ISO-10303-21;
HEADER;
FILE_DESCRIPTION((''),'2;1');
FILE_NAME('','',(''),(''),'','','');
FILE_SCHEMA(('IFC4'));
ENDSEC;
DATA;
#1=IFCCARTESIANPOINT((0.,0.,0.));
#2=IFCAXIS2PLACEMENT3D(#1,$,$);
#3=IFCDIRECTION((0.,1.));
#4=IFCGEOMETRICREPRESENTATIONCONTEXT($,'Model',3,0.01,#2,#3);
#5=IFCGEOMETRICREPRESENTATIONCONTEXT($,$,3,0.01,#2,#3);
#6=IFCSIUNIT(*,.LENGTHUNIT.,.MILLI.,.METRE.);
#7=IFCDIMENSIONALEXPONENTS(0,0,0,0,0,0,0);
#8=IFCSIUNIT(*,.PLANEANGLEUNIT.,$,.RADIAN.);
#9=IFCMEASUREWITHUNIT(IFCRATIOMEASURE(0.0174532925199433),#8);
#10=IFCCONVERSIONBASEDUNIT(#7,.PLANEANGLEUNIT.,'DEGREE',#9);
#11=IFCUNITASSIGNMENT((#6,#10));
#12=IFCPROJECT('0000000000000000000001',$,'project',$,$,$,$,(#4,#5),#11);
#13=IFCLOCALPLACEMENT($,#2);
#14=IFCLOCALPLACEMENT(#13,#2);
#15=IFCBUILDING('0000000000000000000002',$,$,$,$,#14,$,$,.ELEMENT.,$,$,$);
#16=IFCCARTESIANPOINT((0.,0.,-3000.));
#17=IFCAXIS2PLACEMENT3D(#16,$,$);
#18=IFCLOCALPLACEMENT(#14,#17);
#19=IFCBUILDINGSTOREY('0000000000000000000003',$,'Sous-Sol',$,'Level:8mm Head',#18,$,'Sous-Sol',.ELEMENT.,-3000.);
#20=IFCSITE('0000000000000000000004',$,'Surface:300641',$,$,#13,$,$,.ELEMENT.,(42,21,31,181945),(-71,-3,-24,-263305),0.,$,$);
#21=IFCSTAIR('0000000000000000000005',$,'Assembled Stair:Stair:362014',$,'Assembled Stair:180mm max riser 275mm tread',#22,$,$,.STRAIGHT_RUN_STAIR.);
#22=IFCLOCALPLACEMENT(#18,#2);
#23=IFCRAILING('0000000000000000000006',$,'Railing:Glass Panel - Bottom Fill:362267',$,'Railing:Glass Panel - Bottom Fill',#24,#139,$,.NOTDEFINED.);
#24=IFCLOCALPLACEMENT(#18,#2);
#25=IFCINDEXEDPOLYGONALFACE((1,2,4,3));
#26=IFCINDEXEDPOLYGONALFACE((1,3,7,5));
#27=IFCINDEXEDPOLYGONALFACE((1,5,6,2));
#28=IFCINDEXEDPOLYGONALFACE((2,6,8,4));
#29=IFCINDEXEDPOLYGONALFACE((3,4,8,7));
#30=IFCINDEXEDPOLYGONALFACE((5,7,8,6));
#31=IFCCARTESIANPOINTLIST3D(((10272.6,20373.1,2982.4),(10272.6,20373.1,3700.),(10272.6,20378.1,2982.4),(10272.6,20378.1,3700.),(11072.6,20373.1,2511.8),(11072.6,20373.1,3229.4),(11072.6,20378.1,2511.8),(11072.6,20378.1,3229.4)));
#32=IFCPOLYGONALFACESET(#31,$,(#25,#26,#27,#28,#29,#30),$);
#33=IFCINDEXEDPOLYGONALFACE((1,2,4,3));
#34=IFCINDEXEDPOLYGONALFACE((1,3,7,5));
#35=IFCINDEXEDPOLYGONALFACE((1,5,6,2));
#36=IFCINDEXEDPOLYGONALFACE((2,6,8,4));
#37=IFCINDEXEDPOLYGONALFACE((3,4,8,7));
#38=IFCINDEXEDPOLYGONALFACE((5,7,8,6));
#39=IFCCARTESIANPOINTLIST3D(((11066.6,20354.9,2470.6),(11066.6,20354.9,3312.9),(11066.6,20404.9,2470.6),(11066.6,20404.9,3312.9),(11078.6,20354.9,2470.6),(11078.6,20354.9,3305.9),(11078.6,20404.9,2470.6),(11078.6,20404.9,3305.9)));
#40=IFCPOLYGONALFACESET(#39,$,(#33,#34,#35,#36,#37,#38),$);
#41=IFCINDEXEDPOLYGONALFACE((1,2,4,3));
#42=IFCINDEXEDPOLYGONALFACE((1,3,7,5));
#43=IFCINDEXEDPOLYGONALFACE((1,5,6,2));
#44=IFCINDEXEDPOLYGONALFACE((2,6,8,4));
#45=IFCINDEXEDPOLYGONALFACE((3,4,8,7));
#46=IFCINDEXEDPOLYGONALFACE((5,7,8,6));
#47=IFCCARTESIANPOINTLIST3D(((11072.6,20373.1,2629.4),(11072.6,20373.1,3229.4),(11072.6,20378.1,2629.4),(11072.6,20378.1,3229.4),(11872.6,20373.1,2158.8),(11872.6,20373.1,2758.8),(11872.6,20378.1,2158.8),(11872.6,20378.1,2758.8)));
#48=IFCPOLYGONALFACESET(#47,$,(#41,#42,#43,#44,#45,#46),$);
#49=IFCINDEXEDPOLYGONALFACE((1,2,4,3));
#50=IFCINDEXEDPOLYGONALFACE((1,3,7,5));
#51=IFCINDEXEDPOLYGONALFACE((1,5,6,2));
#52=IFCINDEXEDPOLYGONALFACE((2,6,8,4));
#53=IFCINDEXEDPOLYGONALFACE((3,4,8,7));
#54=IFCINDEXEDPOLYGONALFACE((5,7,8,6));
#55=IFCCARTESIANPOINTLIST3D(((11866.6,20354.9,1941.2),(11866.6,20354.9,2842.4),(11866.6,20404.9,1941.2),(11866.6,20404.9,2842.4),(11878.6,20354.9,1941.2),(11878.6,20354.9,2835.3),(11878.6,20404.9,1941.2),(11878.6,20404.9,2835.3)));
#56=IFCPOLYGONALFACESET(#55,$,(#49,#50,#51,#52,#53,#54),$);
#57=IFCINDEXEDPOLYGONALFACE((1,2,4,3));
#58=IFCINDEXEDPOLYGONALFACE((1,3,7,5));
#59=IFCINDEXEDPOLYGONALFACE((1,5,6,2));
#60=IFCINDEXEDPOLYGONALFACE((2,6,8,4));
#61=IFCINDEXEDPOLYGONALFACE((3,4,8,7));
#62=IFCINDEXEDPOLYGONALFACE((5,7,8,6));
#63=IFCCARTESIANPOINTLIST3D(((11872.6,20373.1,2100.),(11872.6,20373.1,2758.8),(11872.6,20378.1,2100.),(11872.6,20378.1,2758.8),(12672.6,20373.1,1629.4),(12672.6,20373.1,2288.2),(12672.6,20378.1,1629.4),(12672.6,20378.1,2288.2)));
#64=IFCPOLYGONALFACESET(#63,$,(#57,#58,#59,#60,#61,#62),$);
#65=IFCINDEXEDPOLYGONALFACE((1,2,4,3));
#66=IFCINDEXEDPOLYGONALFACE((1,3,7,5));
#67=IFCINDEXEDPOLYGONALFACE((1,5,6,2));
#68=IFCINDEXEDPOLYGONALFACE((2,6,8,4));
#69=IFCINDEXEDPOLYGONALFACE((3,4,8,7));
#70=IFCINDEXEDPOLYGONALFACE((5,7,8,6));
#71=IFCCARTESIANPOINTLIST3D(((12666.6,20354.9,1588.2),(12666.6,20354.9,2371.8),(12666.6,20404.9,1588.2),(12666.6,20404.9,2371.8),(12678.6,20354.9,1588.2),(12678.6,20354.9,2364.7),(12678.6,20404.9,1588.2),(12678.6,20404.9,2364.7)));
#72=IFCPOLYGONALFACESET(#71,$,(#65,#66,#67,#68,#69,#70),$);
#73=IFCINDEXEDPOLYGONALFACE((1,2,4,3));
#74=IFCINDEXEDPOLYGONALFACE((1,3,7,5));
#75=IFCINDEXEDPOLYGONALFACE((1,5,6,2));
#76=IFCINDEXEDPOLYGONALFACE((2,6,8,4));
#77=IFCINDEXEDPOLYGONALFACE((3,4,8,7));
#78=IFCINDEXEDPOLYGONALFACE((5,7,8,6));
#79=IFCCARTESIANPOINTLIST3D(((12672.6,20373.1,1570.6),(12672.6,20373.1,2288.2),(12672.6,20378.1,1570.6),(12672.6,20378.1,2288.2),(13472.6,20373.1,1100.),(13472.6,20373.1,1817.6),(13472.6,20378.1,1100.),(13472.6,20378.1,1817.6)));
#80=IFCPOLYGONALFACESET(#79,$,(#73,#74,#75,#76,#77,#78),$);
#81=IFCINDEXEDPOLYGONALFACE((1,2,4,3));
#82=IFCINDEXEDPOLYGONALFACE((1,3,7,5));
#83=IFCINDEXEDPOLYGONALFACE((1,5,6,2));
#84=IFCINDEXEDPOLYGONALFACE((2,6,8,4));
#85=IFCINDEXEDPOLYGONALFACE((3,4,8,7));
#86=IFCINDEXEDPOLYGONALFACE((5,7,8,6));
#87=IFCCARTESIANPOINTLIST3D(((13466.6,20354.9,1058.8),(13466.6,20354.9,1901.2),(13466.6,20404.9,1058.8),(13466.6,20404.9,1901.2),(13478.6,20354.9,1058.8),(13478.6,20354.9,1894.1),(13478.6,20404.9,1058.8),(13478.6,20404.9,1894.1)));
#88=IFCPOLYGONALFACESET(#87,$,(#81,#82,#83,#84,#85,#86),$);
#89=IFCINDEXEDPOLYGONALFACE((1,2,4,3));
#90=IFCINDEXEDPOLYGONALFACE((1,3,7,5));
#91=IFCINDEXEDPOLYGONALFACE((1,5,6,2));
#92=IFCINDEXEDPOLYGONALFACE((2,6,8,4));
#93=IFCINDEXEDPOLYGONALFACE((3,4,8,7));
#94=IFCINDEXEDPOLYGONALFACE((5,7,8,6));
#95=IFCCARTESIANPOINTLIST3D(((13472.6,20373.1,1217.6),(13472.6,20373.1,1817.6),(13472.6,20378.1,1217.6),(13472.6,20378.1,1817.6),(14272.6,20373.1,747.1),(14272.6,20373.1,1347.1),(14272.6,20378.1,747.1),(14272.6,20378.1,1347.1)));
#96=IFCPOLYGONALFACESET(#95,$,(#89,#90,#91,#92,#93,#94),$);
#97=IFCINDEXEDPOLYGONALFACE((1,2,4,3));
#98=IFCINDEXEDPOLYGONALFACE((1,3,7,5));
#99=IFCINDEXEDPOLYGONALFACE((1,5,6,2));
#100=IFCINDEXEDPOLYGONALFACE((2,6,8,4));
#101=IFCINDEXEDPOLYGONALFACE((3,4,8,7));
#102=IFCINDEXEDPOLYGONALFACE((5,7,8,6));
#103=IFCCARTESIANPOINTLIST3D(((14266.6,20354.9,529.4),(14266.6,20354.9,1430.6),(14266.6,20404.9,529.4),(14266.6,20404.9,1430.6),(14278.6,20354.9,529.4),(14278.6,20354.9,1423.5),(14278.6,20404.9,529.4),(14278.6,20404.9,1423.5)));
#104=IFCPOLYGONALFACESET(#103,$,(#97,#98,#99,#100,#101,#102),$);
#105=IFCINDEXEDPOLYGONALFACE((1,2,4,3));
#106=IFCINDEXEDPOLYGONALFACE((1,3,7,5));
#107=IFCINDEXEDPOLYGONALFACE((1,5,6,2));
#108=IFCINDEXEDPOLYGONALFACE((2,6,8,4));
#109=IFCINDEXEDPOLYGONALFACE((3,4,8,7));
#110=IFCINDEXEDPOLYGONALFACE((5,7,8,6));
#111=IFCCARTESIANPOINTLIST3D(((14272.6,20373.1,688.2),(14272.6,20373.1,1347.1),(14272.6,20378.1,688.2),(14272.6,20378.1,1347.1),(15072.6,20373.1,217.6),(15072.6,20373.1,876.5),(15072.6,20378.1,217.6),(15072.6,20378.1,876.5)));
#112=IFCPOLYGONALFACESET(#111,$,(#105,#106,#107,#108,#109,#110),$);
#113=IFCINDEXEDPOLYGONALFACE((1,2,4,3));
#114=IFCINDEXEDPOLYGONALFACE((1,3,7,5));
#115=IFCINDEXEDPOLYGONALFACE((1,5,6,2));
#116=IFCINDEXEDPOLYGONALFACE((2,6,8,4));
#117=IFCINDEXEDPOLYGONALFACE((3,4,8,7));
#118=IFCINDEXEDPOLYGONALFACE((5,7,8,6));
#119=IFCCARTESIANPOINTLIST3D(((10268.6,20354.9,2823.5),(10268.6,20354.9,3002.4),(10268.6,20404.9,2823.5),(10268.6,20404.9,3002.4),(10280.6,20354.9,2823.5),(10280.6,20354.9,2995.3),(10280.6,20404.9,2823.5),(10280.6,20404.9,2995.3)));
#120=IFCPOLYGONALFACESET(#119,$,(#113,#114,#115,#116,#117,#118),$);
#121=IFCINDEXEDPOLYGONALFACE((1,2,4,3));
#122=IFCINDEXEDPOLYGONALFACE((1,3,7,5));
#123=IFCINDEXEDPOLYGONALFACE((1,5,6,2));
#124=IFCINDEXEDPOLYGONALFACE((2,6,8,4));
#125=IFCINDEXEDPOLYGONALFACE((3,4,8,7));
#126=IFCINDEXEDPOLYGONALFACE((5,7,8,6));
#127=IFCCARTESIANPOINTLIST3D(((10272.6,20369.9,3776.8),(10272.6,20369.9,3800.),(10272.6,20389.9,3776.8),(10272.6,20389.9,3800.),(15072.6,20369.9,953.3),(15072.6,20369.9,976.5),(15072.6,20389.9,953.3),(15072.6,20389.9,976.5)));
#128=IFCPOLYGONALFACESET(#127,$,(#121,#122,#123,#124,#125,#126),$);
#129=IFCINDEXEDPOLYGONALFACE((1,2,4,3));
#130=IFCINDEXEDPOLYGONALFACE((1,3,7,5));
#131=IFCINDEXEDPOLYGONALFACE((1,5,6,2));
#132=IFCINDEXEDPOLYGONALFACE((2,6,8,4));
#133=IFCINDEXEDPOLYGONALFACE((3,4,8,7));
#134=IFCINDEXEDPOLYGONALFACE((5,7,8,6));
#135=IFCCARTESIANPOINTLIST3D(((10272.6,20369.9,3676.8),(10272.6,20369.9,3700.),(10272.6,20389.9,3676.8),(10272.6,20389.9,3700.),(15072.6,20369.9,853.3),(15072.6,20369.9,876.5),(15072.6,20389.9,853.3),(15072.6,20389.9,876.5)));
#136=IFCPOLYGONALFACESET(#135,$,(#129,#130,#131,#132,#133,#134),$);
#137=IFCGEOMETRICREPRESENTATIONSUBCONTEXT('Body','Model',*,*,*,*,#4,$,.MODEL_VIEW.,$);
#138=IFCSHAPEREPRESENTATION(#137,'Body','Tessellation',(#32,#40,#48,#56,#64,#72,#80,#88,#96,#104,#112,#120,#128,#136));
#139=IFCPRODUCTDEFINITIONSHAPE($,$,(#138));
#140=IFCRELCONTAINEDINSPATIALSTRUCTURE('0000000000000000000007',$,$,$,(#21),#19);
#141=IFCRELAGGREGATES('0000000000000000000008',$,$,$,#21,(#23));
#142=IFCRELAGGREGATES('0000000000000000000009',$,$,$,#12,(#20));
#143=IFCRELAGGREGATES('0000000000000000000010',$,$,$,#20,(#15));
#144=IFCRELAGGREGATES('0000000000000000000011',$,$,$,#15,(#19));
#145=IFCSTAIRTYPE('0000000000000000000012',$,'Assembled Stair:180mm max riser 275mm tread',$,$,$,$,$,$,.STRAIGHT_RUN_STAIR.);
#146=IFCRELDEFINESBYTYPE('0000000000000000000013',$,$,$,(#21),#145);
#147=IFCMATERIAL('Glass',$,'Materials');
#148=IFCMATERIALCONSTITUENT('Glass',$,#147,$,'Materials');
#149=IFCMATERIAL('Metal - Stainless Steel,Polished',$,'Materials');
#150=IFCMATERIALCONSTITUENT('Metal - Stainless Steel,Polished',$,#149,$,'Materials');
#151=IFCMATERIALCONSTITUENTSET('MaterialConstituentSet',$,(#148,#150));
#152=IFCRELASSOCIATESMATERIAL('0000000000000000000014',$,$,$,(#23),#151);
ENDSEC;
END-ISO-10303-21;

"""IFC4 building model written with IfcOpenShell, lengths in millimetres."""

from ifc_helpers import new_model, entity, si_unit, converted_unit, direction, frame, origin, place, context, subcontext, project, spatial, polyline, outline, extrude, material, constituent, constituent_set, type_object, element, aggregate, save


model = new_model("IFC4")

# Units and contexts
model_context = context("Model", 3, precision=0.01, world=origin(), true_north=direction((0.0, 1.0)))
context_of_model = context(None, 3, precision=0.01, world=origin(), true_north=direction((0.0, 1.0)))
body_context = subcontext(model_context, "Body", "Model", "MODEL_VIEW")
ifc_project = project(units=[si_unit("LENGTHUNIT", "METRE", prefix="MILLI"), converted_unit("PLANEANGLEUNIT", "DEGREE", entity("IfcRatioMeasure", 0.0174532925199433), si_unit("PLANEANGLEUNIT", "RADIAN"), dimensions=[0, 0, 0, 0, 0, 0, 0])], contexts=[model_context, context_of_model])

# Site, building, storey
site_placement = place(None, origin())
site = spatial("IfcSite", under=ifc_project, at=site_placement, Name="Surface:300641", CompositionType="ELEMENT", RefLatitude=(42, 21, 31, 181945), RefLongitude=(-71, -3, -24, -263305), RefElevation=0.0)
building_placement = place(site_placement, origin())
building = spatial("IfcBuilding", under=site, at=building_placement, CompositionType="ELEMENT")
storey_placement = place(building_placement, frame((0.0, 0.0, -3000.0)))
storey = spatial("IfcBuildingStorey", under=building, at=storey_placement, Name="Sous-Sol", ObjectType="Level:8mm Head", LongName="Sous-Sol", CompositionType="ELEMENT", Elevation=-3000.0)

# Stair
stair_type = type_object("IfcStairType", Name="Assembled Stair:180mm max riser 275mm tread", PredefinedType="STRAIGHT_RUN_STAIR")
stair_placement = place(storey_placement, origin())
stair = element("IfcStair", 1, at=stair_placement, inside=storey, type_object=stair_type, Name="Assembled Stair:Stair:362014", ObjectType="Assembled Stair:180mm max riser 275mm tread", PredefinedType="STRAIGHT_RUN_STAIR")

# Shared definitions
ifc_material_1 = material(Name="Glass", Category="Materials")

# Railing
ifc_material_2 = material(Name="Metal - Stainless Steel,Polished", Category="Materials")
ifc_constituent_1 = constituent(ifc_material_1, Name="Glass", Category="Materials")
ifc_constituent_2 = constituent(ifc_material_2, Name="Metal - Stainless Steel,Polished", Category="Materials")
ifc_constituent_set_1 = constituent_set(constituents=[ifc_constituent_1, ifc_constituent_2], Name="MaterialConstituentSet")
railing_1_placement = place(stair_placement, frame((10268.6, 20354.9, 217.6)))
railing_1 = element("IfcRailing", 2, at=railing_1_placement, material=ifc_constituent_set_1, Name="Railing:Glass Panel - Bottom Fill:362267", ObjectType="Railing:Glass Panel - Bottom Fill", PredefinedType="NOTDEFINED", context=body_context, shape_type="SweptSolid", body=[
    extrude(outline(polyline([(-123.5, -400.0), (594.1, -400.0), (123.5, 400.0), (-594.1, 400.0), (-123.5, -400.0)])), frame((404.0, 18.3, 2888.2), z_axis=(0.0, 1.0, 0.0), x_axis=(0.0, 0.0, -1.0)), (0.0, 0.0, 1.0), 5.0),
    extrude(outline(polyline([(-419.4, -6.0), (422.9, -6.0), (415.9, 6.0), (-419.4, 6.0), (-419.4, -6.0)])), frame((804.0, 0.0, 2672.4), z_axis=(0.0, 1.0, 0.0), x_axis=(0.0, 0.0, 1.0)), (0.0, 0.0, 1.0), 50.0),
    extrude(outline(polyline([(-64.7, -400.0), (535.3, -400.0), (64.7, 400.0), (-535.3, 400.0), (-64.7, -400.0)])), frame((1204.0, 18.3, 2476.5), z_axis=(0.0, 1.0, 0.0), x_axis=(0.0, 0.0, -1.0)), (0.0, 0.0, 1.0), 5.0),
    extrude(outline(polyline([(-448.8, -6.0), (452.4, -6.0), (445.3, 6.0), (-448.8, 6.0), (-448.8, -6.0)])), frame((1604.0, 0.0, 2172.4), z_axis=(0.0, 1.0, 0.0), x_axis=(0.0, 0.0, 1.0)), (0.0, 0.0, 1.0), 50.0),
    extrude(outline(polyline([(-94.1, -400.0), (564.7, -400.0), (94.1, 400.0), (-564.7, 400.0), (-94.1, -400.0)])), frame((2004.0, 18.3, 1976.5), z_axis=(0.0, 1.0, 0.0), x_axis=(0.0, 0.0, -1.0)), (0.0, 0.0, 1.0), 5.0),
    extrude(outline(polyline([(-390.0, -6.0), (393.5, -6.0), (386.5, 6.0), (-390.0, 6.0), (-390.0, -6.0)])), frame((2404.0, 0.0, 1760.6), z_axis=(0.0, 1.0, 0.0), x_axis=(0.0, 0.0, 1.0)), (0.0, 0.0, 1.0), 50.0),
    extrude(outline(polyline([(-123.5, -400.0), (594.1, -400.0), (123.5, 400.0), (-594.1, 400.0), (-123.5, -400.0)])), frame((2804.0, 18.3, 1476.5), z_axis=(0.0, 1.0, 0.0), x_axis=(0.0, 0.0, -1.0)), (0.0, 0.0, 1.0), 5.0),
    extrude(outline(polyline([(-419.4, -6.0), (422.9, -6.0), (415.9, 6.0), (-419.4, 6.0), (-419.4, -6.0)])), frame((3204.0, 0.0, 1260.6), z_axis=(0.0, 1.0, 0.0), x_axis=(0.0, 0.0, 1.0)), (0.0, 0.0, 1.0), 50.0),
    extrude(outline(polyline([(-64.7, -400.0), (535.3, -400.0), (64.7, 400.0), (-535.3, 400.0), (-64.7, -400.0)])), frame((3604.0, 18.3, 1064.7), z_axis=(0.0, 1.0, 0.0), x_axis=(0.0, 0.0, -1.0)), (0.0, 0.0, 1.0), 5.0),
    extrude(outline(polyline([(-448.8, -6.0), (452.4, -6.0), (445.3, 6.0), (-448.8, 6.0), (-448.8, -6.0)])), frame((4004.0, 0.0, 760.6), z_axis=(0.0, 1.0, 0.0), x_axis=(0.0, 0.0, 1.0)), (0.0, 0.0, 1.0), 50.0),
    extrude(outline(polyline([(-94.1, -400.0), (564.7, -400.0), (94.1, 400.0), (-564.7, 400.0), (-94.1, -400.0)])), frame((4404.0, 18.3, 564.7), z_axis=(0.0, 1.0, 0.0), x_axis=(0.0, 0.0, -1.0)), (0.0, 0.0, 1.0), 5.0),
    extrude(outline(polyline([(-87.6, -6.0), (91.2, -6.0), (84.1, 6.0), (-87.6, 6.0), (-87.6, -6.0)])), frame((6.0, 0.0, 2693.5), z_axis=(0.0, 1.0, 0.0), x_axis=(0.0, 0.0, 1.0)), (0.0, 0.0, 1.0), 50.0),
    extrude(outline(polyline([(-2790.3, -10.0), (2778.6, -10.0), (2790.3, 10.0), (-2778.6, 10.0), (-2790.3, -10.0)])), frame((2404.0, 15.0, 2159.0), z_axis=(0.0, 1.0, 0.0), x_axis=(-0.861934, 0.0, 0.50702)), (0.0, 0.0, 1.0), 20.0),
    extrude(outline(polyline([(-2790.3, -10.0), (2778.6, -10.0), (2790.3, 10.0), (-2778.6, 10.0), (-2790.3, -10.0)])), frame((2404.0, 15.0, 2059.0), z_axis=(0.0, 1.0, 0.0), x_axis=(-0.861934, 0.0, 0.50702)), (0.0, 0.0, 1.0), 20.0),
])
aggregate(stair, [railing_1])

save(model, "model.ifc")
